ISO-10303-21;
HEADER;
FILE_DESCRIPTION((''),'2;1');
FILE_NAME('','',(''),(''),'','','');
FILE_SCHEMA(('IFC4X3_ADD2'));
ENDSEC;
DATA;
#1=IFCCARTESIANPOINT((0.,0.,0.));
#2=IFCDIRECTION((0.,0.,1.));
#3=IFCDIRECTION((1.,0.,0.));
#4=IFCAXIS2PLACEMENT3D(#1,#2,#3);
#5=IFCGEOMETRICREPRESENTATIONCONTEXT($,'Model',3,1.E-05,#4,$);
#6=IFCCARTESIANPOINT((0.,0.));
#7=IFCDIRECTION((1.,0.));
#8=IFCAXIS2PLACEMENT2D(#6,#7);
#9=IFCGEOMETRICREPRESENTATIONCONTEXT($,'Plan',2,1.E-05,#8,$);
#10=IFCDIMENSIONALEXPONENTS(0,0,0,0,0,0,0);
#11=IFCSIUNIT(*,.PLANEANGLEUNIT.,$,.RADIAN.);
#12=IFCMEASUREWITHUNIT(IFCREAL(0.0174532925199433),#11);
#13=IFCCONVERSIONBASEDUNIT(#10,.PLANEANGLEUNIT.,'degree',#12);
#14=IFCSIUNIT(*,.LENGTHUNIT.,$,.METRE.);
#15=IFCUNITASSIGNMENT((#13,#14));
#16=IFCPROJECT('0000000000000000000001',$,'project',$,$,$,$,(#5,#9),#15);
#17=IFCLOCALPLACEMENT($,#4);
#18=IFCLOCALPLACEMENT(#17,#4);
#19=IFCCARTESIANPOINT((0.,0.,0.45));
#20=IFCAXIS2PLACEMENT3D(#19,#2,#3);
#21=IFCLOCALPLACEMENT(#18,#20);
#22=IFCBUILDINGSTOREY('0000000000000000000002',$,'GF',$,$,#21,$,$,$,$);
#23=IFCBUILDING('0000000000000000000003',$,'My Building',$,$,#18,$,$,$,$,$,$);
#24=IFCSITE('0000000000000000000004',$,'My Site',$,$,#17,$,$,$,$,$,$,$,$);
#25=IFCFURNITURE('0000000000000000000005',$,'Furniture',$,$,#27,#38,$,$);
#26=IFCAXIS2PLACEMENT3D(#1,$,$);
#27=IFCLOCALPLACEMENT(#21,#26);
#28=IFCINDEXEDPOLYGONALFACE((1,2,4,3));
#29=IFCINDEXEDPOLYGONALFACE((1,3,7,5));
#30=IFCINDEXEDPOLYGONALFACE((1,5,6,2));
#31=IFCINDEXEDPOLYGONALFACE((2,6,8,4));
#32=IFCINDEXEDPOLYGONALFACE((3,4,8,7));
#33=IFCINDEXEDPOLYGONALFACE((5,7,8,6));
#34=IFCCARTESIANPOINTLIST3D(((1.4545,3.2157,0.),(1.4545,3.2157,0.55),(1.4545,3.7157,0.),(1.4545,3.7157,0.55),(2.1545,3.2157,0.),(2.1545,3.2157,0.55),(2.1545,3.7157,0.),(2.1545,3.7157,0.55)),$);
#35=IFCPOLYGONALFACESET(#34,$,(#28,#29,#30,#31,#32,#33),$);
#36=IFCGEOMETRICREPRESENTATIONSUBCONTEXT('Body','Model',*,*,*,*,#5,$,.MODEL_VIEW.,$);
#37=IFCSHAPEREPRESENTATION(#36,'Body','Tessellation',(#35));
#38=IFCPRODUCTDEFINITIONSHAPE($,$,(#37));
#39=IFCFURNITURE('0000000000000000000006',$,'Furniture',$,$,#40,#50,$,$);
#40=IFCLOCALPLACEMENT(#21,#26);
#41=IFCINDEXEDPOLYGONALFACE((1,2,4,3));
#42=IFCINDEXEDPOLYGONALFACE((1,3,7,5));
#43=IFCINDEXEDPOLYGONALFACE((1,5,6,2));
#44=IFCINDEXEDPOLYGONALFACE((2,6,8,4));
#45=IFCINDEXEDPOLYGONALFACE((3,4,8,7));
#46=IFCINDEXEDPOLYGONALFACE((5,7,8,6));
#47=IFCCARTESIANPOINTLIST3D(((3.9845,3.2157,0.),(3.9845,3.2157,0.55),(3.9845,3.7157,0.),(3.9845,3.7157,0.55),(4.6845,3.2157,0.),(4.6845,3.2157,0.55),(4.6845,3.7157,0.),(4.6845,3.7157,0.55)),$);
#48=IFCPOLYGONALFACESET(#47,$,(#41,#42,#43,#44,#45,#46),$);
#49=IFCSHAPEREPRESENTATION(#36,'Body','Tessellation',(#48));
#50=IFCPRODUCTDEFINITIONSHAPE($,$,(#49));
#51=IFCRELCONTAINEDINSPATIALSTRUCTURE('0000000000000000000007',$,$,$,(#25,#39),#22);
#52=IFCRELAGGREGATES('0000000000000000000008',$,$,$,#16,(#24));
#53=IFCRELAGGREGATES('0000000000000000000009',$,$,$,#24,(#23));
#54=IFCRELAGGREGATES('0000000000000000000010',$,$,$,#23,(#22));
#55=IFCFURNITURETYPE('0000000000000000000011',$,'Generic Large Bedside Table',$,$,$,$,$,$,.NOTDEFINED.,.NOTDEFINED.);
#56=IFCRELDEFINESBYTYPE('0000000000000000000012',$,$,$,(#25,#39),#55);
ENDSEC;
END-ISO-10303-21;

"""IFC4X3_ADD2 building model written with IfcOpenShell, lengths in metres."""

from ifc_helpers import new_model, entity, si_unit, converted_unit, frame, origin_with_axes, origin_2d_with_axis, place, context, subcontext, project, spatial, line, indexed_curve, outline, extrude, shape, source, transform, mapped, type_object, type_shapes, element, save


model = new_model("IFC4X3_ADD2")

# Units and contexts
model_context = context("Model", 3, precision=1e-05, world=origin_with_axes())
plan_context = context("Plan", 2, precision=1e-05, world=origin_2d_with_axis())
body_context_1 = subcontext(model_context, "Body", "Model", "MODEL_VIEW")
body_context_2 = subcontext(plan_context, "Body", "Plan", "PLAN_VIEW")
ifc_project = project(units=[converted_unit("PLANEANGLEUNIT", "degree", entity("IfcReal", 0.0174532925199433), si_unit("PLANEANGLEUNIT", "RADIAN"), dimensions=[0, 0, 0, 0, 0, 0, 0]), si_unit("LENGTHUNIT", "METRE")], contexts=[model_context, plan_context])

# Site, building, storey
site_placement = place(None, origin_with_axes())
site = spatial("IfcSite", under=ifc_project, at=site_placement, Name="My Site")
building_placement = place(site_placement, origin_with_axes())
building = spatial("IfcBuilding", under=site, at=building_placement, Name="My Building")
storey_placement = place(building_placement, frame((0.0, 0.0, 0.45), z_axis=(0.0, 0.0, 1.0), x_axis=(1.0, 0.0, 0.0)))
storey = spatial("IfcBuildingStorey", under=building, at=storey_placement, Name="GF")

# Furniture
furniture_type_1 = type_object("IfcFurnitureType", Name="Generic Large Bedside Table", AssemblyPlace="NOTDEFINED", PredefinedType="NOTDEFINED")
shared_shape_1 = source(origin_with_axes(), body_context_1, "Body", "SweptSolid", [
    extrude(outline(indexed_curve([(0.0, 0.0), (0.7, 0.0), (0.7, 0.5), (0.0, 0.5)], segments=[line(1, 2, 3, 4, 1)])), frame((-0.35, -0.25, 0.0), z_axis=(0.0, 0.0, 1.0), x_axis=(1.0, 0.0, 0.0)), (0.0, 0.0, 1.0), 0.55),
])
shared_shape_2 = source(origin_with_axes(), body_context_2, "Body", "Curve2D", [
    entity("IfcIndexedPolyCurve", entity("IfcCartesianPointList2D", [[-0.35, -0.25], [0.35, -0.25], [0.35, 0.25], [-0.35, 0.25]]), [entity("IfcLineIndex", [1, 2, 3, 4, 1])]),
])
type_shapes(furniture_type_1, [shared_shape_1, shared_shape_2])
for number, where, z_axis, x_axis, name in (
    (1, (1.8045, 3.4657, 0.0), (0.0, 0.0, 1.0), (1.0, 0.0, 0.0), "Furniture"),
    (2, (4.3345, 3.4657, 0.0), (0.0, 0.0, 1.0), (1.0, 0.0, 0.0), "Furniture"),
):
    element("IfcFurniture", number, at=place(storey_placement, frame(where, z_axis=z_axis, x_axis=x_axis)), inside=storey, type_object=furniture_type_1, Name=name, shapes=[
        shape(body_context_1, "Body", "MappedRepresentation", [mapped(shared_shape_1, transform((0.0, 0.0, 0.0), x_axis=(1.0, 0.0, 0.0), y_axis=(0.0, 1.0, 0.0), z_axis=(0.0, 0.0, 1.0), scale=1.0))]),
        shape(body_context_2, "Body", "MappedRepresentation", [mapped(shared_shape_2, transform((0.0, 0.0, 0.0), x_axis=(1.0, 0.0, 0.0), y_axis=(0.0, 1.0, 0.0), z_axis=(0.0, 0.0, 1.0), scale=1.0))]),
    ])

save(model, "model.ifc")
